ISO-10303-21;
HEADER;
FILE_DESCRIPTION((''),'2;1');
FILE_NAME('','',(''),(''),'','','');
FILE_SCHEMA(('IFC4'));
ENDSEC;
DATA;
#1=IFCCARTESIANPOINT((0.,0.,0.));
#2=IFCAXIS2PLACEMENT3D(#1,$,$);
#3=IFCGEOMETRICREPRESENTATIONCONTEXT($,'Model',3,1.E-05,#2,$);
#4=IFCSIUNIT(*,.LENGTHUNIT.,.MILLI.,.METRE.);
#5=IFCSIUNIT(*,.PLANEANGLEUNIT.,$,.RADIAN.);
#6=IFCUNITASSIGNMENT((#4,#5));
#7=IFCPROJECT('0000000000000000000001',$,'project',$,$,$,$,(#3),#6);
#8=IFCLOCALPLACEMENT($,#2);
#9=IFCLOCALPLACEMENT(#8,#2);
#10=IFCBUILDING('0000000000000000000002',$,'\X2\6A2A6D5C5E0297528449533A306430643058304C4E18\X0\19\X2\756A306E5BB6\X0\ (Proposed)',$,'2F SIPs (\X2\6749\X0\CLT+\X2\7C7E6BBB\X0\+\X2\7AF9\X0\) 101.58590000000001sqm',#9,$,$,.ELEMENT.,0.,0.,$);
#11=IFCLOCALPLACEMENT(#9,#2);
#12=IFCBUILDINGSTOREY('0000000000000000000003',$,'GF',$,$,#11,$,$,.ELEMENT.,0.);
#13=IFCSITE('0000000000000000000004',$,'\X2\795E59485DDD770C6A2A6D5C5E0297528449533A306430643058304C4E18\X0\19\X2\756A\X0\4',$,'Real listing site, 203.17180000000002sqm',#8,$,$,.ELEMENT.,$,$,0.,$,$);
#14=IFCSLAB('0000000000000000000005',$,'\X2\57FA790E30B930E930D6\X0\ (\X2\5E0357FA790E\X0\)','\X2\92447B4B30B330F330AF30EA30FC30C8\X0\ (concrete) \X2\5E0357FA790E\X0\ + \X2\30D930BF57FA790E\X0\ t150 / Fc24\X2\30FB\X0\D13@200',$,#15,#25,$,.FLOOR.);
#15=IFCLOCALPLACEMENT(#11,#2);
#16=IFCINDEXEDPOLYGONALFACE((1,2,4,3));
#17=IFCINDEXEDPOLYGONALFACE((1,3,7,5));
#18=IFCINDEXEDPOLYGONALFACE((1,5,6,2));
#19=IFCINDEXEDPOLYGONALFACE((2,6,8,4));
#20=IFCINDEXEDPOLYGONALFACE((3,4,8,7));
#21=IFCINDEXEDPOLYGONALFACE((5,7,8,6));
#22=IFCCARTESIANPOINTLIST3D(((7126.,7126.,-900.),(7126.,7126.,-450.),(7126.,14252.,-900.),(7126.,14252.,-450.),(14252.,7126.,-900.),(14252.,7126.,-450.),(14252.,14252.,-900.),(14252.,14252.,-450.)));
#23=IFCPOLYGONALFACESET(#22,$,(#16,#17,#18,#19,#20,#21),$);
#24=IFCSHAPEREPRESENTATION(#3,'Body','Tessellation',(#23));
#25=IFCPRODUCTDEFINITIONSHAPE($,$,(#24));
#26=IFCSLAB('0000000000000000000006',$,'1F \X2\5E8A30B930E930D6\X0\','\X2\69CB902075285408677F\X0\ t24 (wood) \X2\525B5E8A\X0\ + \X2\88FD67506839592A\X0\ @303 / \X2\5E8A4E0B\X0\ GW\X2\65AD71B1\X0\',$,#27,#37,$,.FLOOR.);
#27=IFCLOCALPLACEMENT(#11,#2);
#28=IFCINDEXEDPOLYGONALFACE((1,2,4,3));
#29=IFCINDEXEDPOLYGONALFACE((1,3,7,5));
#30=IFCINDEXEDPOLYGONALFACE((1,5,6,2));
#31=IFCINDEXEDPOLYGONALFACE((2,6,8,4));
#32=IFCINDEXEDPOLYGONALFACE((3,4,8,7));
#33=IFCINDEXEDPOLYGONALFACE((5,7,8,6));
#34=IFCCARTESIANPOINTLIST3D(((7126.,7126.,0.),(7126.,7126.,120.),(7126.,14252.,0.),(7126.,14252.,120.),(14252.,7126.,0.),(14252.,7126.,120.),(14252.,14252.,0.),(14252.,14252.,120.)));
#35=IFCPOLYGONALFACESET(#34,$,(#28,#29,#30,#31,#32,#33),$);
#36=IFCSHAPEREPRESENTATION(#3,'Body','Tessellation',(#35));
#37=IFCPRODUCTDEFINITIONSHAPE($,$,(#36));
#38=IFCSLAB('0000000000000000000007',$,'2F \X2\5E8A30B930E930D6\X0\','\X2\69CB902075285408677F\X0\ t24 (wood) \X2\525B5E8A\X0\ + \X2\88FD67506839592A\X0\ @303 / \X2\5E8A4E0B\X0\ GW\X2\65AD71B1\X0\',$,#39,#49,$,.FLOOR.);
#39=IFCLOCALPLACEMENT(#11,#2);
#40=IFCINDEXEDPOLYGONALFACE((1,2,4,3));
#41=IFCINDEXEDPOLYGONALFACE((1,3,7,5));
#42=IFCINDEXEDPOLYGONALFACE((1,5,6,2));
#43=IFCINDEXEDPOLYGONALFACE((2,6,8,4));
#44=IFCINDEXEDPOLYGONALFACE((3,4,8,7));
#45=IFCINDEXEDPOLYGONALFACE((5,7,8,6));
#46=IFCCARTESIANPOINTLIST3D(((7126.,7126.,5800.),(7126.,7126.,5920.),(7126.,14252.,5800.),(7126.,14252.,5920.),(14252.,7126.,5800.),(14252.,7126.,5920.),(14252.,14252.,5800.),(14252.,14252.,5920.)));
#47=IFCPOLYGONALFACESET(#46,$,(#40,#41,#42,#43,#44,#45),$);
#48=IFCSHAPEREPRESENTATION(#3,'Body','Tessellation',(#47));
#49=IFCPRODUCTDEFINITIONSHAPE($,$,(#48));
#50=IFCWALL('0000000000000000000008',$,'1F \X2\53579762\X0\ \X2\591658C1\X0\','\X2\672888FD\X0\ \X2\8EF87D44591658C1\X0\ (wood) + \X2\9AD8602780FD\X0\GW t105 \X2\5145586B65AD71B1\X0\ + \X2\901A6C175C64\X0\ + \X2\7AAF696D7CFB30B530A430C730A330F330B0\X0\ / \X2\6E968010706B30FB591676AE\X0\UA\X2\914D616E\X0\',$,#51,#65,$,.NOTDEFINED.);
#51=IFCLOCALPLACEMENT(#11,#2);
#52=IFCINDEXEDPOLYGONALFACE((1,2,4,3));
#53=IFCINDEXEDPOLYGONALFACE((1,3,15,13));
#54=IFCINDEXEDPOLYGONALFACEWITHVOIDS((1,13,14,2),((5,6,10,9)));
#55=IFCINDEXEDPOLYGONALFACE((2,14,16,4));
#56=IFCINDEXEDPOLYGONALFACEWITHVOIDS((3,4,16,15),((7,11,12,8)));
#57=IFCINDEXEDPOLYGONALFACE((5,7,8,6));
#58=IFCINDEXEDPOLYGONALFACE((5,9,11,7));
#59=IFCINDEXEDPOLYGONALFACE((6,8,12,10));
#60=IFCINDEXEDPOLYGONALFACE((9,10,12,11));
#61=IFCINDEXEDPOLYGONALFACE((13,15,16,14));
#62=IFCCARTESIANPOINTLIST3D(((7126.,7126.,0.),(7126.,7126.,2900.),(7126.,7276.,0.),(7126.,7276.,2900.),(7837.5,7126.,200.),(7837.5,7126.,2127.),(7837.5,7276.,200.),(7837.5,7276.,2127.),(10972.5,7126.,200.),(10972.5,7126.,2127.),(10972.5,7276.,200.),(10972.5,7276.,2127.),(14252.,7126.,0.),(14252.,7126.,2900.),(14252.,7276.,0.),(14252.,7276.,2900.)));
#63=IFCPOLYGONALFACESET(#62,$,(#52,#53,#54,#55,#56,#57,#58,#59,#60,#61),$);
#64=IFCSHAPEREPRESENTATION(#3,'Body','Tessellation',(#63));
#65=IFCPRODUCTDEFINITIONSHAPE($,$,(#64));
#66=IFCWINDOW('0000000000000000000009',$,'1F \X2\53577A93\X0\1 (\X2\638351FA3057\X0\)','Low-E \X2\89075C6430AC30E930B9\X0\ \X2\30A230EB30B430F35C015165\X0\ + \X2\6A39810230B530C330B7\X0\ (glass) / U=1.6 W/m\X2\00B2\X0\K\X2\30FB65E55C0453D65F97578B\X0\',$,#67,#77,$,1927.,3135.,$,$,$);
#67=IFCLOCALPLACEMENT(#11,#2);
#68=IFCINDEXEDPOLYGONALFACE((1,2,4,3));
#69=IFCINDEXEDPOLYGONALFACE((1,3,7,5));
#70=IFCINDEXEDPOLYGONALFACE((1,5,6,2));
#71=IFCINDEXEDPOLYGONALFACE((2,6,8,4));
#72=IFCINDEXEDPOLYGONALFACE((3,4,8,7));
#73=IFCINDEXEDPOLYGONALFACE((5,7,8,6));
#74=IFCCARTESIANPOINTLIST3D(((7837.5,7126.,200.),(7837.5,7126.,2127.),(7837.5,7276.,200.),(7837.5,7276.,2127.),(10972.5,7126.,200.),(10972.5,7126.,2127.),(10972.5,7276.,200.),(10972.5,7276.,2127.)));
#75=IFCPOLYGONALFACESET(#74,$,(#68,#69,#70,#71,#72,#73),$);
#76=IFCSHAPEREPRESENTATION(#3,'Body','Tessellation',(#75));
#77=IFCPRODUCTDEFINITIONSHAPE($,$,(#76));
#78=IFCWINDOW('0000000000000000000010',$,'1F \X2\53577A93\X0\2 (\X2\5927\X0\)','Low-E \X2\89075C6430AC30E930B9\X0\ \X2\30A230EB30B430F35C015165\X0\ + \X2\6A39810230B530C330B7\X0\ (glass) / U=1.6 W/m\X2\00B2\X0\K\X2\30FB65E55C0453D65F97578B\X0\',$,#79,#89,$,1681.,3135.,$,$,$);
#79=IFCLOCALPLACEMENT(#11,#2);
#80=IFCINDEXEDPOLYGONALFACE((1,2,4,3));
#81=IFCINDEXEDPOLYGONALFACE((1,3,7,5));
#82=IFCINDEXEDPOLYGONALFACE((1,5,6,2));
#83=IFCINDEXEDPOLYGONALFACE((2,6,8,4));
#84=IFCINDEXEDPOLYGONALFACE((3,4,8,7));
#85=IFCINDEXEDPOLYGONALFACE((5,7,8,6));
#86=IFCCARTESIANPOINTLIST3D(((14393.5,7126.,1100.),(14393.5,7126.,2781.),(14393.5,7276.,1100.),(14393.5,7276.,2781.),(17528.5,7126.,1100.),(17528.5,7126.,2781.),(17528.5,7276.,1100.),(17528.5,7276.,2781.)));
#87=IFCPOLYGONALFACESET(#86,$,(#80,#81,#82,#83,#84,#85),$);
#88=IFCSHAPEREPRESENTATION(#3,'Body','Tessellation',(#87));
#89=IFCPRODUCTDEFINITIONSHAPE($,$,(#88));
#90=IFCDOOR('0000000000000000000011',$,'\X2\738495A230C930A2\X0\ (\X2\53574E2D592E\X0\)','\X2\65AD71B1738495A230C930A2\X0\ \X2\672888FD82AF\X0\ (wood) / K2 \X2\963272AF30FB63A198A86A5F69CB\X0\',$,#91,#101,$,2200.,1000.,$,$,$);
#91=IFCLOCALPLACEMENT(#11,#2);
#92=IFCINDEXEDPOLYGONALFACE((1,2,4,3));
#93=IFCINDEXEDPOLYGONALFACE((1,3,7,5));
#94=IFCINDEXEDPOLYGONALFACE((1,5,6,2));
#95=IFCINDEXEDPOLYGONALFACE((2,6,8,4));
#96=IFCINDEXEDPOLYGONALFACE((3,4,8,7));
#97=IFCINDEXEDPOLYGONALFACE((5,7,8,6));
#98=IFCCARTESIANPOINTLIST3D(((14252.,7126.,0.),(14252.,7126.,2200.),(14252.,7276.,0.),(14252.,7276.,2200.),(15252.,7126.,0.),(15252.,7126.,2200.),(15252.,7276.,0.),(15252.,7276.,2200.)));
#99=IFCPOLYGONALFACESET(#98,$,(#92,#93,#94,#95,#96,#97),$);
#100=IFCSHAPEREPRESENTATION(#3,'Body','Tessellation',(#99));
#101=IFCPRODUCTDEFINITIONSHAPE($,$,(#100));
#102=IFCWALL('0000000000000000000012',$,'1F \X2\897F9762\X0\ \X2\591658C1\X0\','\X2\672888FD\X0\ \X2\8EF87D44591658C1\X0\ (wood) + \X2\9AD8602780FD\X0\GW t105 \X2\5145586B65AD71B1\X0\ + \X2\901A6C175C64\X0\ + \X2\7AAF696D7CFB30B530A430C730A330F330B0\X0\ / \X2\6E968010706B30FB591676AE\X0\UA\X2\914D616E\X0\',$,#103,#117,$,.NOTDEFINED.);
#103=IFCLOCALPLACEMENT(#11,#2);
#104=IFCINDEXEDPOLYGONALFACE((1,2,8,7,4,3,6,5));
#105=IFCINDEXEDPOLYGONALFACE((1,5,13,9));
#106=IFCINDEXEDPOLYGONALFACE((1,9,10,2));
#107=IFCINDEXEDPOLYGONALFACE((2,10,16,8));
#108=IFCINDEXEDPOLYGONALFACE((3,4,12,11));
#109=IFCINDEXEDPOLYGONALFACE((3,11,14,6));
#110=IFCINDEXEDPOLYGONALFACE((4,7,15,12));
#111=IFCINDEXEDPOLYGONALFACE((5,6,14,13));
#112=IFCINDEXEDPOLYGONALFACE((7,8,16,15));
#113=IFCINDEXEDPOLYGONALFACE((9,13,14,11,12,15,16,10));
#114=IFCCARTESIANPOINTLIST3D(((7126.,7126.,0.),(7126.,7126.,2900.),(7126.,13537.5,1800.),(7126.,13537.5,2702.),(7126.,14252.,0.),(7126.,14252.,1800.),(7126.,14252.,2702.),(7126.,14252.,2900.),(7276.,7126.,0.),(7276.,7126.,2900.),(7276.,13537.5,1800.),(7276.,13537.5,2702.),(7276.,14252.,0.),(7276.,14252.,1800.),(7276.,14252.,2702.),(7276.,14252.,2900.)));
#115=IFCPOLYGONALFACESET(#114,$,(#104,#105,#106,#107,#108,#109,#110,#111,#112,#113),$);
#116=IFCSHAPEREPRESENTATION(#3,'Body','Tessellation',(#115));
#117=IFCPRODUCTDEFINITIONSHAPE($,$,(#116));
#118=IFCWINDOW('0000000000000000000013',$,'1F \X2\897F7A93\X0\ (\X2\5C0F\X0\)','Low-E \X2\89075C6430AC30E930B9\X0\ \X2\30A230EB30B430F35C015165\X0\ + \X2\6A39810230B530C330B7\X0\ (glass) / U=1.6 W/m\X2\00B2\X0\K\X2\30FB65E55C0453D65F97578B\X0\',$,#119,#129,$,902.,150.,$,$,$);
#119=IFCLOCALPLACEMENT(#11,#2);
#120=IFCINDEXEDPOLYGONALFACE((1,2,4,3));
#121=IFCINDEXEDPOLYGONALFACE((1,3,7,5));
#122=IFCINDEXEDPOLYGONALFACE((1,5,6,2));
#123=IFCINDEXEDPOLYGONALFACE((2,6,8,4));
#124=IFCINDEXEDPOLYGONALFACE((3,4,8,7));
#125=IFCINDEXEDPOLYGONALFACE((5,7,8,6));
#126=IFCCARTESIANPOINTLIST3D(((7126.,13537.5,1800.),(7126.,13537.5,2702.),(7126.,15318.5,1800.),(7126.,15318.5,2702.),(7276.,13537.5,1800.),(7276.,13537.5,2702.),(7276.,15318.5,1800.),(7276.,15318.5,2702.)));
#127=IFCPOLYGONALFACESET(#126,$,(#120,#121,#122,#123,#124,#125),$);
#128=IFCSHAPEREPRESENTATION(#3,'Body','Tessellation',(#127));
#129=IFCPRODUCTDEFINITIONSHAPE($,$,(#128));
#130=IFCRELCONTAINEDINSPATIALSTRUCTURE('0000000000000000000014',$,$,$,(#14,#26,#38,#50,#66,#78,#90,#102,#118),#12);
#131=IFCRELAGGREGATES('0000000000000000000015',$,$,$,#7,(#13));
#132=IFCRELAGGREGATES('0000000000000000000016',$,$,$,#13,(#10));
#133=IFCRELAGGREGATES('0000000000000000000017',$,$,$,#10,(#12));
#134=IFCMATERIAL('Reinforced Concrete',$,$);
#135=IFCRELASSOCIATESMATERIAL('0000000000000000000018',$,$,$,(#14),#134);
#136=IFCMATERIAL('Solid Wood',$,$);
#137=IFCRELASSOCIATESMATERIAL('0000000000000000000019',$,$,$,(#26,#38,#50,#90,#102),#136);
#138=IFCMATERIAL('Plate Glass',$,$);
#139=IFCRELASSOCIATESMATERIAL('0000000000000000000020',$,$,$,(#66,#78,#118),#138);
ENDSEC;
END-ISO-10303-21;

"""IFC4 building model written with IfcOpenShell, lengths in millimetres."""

from ifc_helpers import new_model, si_unit, frame, frame_2d, origin, place, context, project, spatial, rectangle, extrude, material, element, fill, save


model = new_model("IFC4")

# Units and contexts
model_context = context("Model", 3, precision=1e-05, world=origin())
ifc_project = project(units=[si_unit("LENGTHUNIT", "METRE", prefix="MILLI"), si_unit("PLANEANGLEUNIT", "RADIAN")], contexts=[model_context])

# Site, building, storey
site_placement = place(None, origin())
site = spatial("IfcSite", under=ifc_project, at=site_placement, Name="神奈川県横浜市青葉区つつじが丘19番4", ObjectType="Real listing site, 203.17180000000002sqm", CompositionType="ELEMENT", RefElevation=0.0)
building_placement = place(site_placement, origin())
building = spatial("IfcBuilding", under=site, at=building_placement, Name="横浜市青葉区つつじが丘19番の家 (Proposed)", ObjectType="2F SIPs (杉CLT+籾殻+竹) 101.58590000000001sqm", CompositionType="ELEMENT", ElevationOfRefHeight=0.0, ElevationOfTerrain=0.0)
storey_placement = place(building_placement, origin())
storey = spatial("IfcBuildingStorey", under=building, at=storey_placement, Name="GF", CompositionType="ELEMENT", Elevation=0.0)

# Slabs
ifc_material_1 = material(Name="Reinforced Concrete")
slab_1_placement = place(storey_placement, frame((3563.0, 3563.0, -450.0)))
element("IfcSlab", 1, at=slab_1_placement, inside=storey, material=ifc_material_1, Name="基礎スラブ (布基礎)", Description="鉄筋コンクリート (concrete) 布基礎 + ベタ基礎 t150 / Fc24・D13@200", PredefinedType="FLOOR", context=model_context, shape_type="SweptSolid", body=[
    extrude(rectangle(XDim=7126.0, YDim=7126.0, at=frame_2d((3563.0, 3563.0))), frame((3563.0, 3563.0, -450.0)), (0.0, 0.0, 1.0), 450.0),
])
ifc_material_2 = material(Name="Solid Wood")
slab_2_placement = place(storey_placement, frame((3563.0, 3563.0, 0.0)))
element("IfcSlab", 2, at=slab_2_placement, inside=storey, material=ifc_material_2, Name="1F 床スラブ", Description="構造用合板 t24 (wood) 剛床 + 製材根太 @303 / 床下 GW断熱", PredefinedType="FLOOR", context=model_context, shape_type="SweptSolid", body=[
    extrude(rectangle(XDim=7126.0, YDim=7126.0, at=frame_2d((3563.0, 3563.0))), frame((3563.0, 3563.0, 0.0)), (0.0, 0.0, 1.0), 120.0),
])
slab_3_placement = place(storey_placement, frame((3563.0, 3563.0, 2900.0)))
element("IfcSlab", 3, at=slab_3_placement, inside=storey, material=ifc_material_2, Name="2F 床スラブ", Description="構造用合板 t24 (wood) 剛床 + 製材根太 @303 / 床下 GW断熱", PredefinedType="FLOOR", context=model_context, shape_type="SweptSolid", body=[
    extrude(rectangle(XDim=7126.0, YDim=7126.0, at=frame_2d((3563.0, 3563.0))), frame((3563.0, 3563.0, 2900.0)), (0.0, 0.0, 1.0), 120.0),
])

# Wall, openings, windows, door
wall_1_placement = place(storey_placement, frame((3563.0, 3563.0, 0.0)))
wall_1 = element("IfcWall", 4, at=wall_1_placement, inside=storey, material=ifc_material_2, Name="1F 南面 外壁", Description="木製 軸組外壁 (wood) + 高性能GW t105 充填断熱 + 通気層 + 窯業系サイディング / 準耐火・外皮UA配慮", PredefinedType="NOTDEFINED", context=model_context, shape_type="SweptSolid", body=[
    extrude(rectangle(XDim=7126.0, YDim=150.0, at=frame_2d((3563.0, 75.0))), frame((3563.0, 3563.0, 0.0)), (0.0, 0.0, 1.0), 2900.0),
])
opening_1_placement = place(storey_placement, frame((3919.0, 3563.0, 100.0)))
opening_1 = element("IfcOpeningElement", 5, at=opening_1_placement, cuts=wall_1, PredefinedType="NOTDEFINED", context=model_context, shape_type="SweptSolid", body=[
    extrude(rectangle(XDim=3135.0, YDim=150.0, at=frame_2d((1567.0, 75.0))), frame((3919.0, 3563.0, 100.0)), (0.0, 0.0, 1.0), 1927.0),
])
opening_2_placement = place(storey_placement, frame((7197.0, 3563.0, 550.0)))
opening_2 = element("IfcOpeningElement", 6, at=opening_2_placement, cuts=wall_1, PredefinedType="NOTDEFINED", context=model_context, shape_type="SweptSolid", body=[
    extrude(rectangle(XDim=3135.0, YDim=150.0, at=frame_2d((1567.0, 75.0))), frame((7197.0, 3563.0, 550.0)), (0.0, 0.0, 1.0), 1681.0),
])
opening_3_placement = place(storey_placement, frame((7126.0, 3563.0, 0.0)))
opening_3 = element("IfcOpeningElement", 7, at=opening_3_placement, cuts=wall_1, PredefinedType="NOTDEFINED", context=model_context, shape_type="SweptSolid", body=[
    extrude(rectangle(XDim=1000.0, YDim=150.0, at=frame_2d((500.0, 75.0))), frame((7126.0, 3563.0, 0.0)), (0.0, 0.0, 1.0), 2200.0),
])
ifc_material_3 = material(Name="Plate Glass")
window_1_placement = place(storey_placement, frame((3919.0, 3563.0, 100.0)))
window_1 = element("IfcWindow", 8, at=window_1_placement, inside=storey, material=ifc_material_3, Name="1F 南窓1 (掃出し)", Description="Low-E 複層ガラス アルゴン封入 + 樹脂サッシ (glass) / U=1.6 W/m²K・日射取得型", OverallHeight=1927.0, OverallWidth=3135.0, context=model_context, shape_type="SweptSolid", body=[
    extrude(rectangle(XDim=3135.0, YDim=150.0, at=frame_2d((1567.0, 75.0))), frame((3919.0, 3563.0, 100.0)), (0.0, 0.0, 1.0), 1927.0),
])
fill(opening_1, window_1)
window_2_placement = place(storey_placement, frame((7197.0, 3563.0, 550.0)))
window_2 = element("IfcWindow", 9, at=window_2_placement, inside=storey, material=ifc_material_3, Name="1F 南窓2 (大)", Description="Low-E 複層ガラス アルゴン封入 + 樹脂サッシ (glass) / U=1.6 W/m²K・日射取得型", OverallHeight=1681.0, OverallWidth=3135.0, context=model_context, shape_type="SweptSolid", body=[
    extrude(rectangle(XDim=3135.0, YDim=150.0, at=frame_2d((1567.0, 75.0))), frame((7197.0, 3563.0, 550.0)), (0.0, 0.0, 1.0), 1681.0),
])
fill(opening_2, window_2)
door_placement = place(storey_placement, frame((7126.0, 3563.0, 0.0)))
door = element("IfcDoor", 10, at=door_placement, inside=storey, material=ifc_material_2, Name="玄関ドア (南中央)", Description="断熱玄関ドア 木製芯 (wood) / K2 防犯・採風機構", OverallHeight=2200.0, OverallWidth=1000.0, context=model_context, shape_type="SweptSolid", body=[
    extrude(rectangle(XDim=1000.0, YDim=150.0, at=frame_2d((500.0, 75.0))), frame((7126.0, 3563.0, 0.0)), (0.0, 0.0, 1.0), 2200.0),
])
fill(opening_3, door)

# Wall, opening, window
wall_2_placement = place(storey_placement, frame((3563.0, 3563.0, 0.0)))
wall_2 = element("IfcWall", 11, at=wall_2_placement, inside=storey, material=ifc_material_2, Name="1F 西面 外壁", Description="木製 軸組外壁 (wood) + 高性能GW t105 充填断熱 + 通気層 + 窯業系サイディング / 準耐火・外皮UA配慮", PredefinedType="NOTDEFINED", context=model_context, shape_type="SweptSolid", body=[
    extrude(rectangle(XDim=150.0, YDim=7126.0, at=frame_2d((75.0, 3563.0))), frame((3563.0, 3563.0, 0.0)), (0.0, 0.0, 1.0), 2900.0),
])
opening_4_placement = place(storey_placement, frame((3563.0, 6769.0, 900.0)))
opening_4 = element("IfcOpeningElement", 12, at=opening_4_placement, cuts=wall_2, PredefinedType="NOTDEFINED", context=model_context, shape_type="SweptSolid", body=[
    extrude(rectangle(XDim=150.0, YDim=1781.0, at=frame_2d((75.0, 890.0))), frame((3563.0, 6769.0, 900.0)), (0.0, 0.0, 1.0), 902.0),
])
window_3_placement = place(storey_placement, frame((3563.0, 6769.0, 900.0)))
window_3 = element("IfcWindow", 13, at=window_3_placement, inside=storey, material=ifc_material_3, Name="1F 西窓 (小)", Description="Low-E 複層ガラス アルゴン封入 + 樹脂サッシ (glass) / U=1.6 W/m²K・日射取得型", OverallHeight=902.0, OverallWidth=150.0, context=model_context, shape_type="SweptSolid", body=[
    extrude(rectangle(XDim=150.0, YDim=1781.0, at=frame_2d((75.0, 890.0))), frame((3563.0, 6769.0, 900.0)), (0.0, 0.0, 1.0), 902.0),
])
fill(opening_4, window_3)

save(model, "model.ifc")
